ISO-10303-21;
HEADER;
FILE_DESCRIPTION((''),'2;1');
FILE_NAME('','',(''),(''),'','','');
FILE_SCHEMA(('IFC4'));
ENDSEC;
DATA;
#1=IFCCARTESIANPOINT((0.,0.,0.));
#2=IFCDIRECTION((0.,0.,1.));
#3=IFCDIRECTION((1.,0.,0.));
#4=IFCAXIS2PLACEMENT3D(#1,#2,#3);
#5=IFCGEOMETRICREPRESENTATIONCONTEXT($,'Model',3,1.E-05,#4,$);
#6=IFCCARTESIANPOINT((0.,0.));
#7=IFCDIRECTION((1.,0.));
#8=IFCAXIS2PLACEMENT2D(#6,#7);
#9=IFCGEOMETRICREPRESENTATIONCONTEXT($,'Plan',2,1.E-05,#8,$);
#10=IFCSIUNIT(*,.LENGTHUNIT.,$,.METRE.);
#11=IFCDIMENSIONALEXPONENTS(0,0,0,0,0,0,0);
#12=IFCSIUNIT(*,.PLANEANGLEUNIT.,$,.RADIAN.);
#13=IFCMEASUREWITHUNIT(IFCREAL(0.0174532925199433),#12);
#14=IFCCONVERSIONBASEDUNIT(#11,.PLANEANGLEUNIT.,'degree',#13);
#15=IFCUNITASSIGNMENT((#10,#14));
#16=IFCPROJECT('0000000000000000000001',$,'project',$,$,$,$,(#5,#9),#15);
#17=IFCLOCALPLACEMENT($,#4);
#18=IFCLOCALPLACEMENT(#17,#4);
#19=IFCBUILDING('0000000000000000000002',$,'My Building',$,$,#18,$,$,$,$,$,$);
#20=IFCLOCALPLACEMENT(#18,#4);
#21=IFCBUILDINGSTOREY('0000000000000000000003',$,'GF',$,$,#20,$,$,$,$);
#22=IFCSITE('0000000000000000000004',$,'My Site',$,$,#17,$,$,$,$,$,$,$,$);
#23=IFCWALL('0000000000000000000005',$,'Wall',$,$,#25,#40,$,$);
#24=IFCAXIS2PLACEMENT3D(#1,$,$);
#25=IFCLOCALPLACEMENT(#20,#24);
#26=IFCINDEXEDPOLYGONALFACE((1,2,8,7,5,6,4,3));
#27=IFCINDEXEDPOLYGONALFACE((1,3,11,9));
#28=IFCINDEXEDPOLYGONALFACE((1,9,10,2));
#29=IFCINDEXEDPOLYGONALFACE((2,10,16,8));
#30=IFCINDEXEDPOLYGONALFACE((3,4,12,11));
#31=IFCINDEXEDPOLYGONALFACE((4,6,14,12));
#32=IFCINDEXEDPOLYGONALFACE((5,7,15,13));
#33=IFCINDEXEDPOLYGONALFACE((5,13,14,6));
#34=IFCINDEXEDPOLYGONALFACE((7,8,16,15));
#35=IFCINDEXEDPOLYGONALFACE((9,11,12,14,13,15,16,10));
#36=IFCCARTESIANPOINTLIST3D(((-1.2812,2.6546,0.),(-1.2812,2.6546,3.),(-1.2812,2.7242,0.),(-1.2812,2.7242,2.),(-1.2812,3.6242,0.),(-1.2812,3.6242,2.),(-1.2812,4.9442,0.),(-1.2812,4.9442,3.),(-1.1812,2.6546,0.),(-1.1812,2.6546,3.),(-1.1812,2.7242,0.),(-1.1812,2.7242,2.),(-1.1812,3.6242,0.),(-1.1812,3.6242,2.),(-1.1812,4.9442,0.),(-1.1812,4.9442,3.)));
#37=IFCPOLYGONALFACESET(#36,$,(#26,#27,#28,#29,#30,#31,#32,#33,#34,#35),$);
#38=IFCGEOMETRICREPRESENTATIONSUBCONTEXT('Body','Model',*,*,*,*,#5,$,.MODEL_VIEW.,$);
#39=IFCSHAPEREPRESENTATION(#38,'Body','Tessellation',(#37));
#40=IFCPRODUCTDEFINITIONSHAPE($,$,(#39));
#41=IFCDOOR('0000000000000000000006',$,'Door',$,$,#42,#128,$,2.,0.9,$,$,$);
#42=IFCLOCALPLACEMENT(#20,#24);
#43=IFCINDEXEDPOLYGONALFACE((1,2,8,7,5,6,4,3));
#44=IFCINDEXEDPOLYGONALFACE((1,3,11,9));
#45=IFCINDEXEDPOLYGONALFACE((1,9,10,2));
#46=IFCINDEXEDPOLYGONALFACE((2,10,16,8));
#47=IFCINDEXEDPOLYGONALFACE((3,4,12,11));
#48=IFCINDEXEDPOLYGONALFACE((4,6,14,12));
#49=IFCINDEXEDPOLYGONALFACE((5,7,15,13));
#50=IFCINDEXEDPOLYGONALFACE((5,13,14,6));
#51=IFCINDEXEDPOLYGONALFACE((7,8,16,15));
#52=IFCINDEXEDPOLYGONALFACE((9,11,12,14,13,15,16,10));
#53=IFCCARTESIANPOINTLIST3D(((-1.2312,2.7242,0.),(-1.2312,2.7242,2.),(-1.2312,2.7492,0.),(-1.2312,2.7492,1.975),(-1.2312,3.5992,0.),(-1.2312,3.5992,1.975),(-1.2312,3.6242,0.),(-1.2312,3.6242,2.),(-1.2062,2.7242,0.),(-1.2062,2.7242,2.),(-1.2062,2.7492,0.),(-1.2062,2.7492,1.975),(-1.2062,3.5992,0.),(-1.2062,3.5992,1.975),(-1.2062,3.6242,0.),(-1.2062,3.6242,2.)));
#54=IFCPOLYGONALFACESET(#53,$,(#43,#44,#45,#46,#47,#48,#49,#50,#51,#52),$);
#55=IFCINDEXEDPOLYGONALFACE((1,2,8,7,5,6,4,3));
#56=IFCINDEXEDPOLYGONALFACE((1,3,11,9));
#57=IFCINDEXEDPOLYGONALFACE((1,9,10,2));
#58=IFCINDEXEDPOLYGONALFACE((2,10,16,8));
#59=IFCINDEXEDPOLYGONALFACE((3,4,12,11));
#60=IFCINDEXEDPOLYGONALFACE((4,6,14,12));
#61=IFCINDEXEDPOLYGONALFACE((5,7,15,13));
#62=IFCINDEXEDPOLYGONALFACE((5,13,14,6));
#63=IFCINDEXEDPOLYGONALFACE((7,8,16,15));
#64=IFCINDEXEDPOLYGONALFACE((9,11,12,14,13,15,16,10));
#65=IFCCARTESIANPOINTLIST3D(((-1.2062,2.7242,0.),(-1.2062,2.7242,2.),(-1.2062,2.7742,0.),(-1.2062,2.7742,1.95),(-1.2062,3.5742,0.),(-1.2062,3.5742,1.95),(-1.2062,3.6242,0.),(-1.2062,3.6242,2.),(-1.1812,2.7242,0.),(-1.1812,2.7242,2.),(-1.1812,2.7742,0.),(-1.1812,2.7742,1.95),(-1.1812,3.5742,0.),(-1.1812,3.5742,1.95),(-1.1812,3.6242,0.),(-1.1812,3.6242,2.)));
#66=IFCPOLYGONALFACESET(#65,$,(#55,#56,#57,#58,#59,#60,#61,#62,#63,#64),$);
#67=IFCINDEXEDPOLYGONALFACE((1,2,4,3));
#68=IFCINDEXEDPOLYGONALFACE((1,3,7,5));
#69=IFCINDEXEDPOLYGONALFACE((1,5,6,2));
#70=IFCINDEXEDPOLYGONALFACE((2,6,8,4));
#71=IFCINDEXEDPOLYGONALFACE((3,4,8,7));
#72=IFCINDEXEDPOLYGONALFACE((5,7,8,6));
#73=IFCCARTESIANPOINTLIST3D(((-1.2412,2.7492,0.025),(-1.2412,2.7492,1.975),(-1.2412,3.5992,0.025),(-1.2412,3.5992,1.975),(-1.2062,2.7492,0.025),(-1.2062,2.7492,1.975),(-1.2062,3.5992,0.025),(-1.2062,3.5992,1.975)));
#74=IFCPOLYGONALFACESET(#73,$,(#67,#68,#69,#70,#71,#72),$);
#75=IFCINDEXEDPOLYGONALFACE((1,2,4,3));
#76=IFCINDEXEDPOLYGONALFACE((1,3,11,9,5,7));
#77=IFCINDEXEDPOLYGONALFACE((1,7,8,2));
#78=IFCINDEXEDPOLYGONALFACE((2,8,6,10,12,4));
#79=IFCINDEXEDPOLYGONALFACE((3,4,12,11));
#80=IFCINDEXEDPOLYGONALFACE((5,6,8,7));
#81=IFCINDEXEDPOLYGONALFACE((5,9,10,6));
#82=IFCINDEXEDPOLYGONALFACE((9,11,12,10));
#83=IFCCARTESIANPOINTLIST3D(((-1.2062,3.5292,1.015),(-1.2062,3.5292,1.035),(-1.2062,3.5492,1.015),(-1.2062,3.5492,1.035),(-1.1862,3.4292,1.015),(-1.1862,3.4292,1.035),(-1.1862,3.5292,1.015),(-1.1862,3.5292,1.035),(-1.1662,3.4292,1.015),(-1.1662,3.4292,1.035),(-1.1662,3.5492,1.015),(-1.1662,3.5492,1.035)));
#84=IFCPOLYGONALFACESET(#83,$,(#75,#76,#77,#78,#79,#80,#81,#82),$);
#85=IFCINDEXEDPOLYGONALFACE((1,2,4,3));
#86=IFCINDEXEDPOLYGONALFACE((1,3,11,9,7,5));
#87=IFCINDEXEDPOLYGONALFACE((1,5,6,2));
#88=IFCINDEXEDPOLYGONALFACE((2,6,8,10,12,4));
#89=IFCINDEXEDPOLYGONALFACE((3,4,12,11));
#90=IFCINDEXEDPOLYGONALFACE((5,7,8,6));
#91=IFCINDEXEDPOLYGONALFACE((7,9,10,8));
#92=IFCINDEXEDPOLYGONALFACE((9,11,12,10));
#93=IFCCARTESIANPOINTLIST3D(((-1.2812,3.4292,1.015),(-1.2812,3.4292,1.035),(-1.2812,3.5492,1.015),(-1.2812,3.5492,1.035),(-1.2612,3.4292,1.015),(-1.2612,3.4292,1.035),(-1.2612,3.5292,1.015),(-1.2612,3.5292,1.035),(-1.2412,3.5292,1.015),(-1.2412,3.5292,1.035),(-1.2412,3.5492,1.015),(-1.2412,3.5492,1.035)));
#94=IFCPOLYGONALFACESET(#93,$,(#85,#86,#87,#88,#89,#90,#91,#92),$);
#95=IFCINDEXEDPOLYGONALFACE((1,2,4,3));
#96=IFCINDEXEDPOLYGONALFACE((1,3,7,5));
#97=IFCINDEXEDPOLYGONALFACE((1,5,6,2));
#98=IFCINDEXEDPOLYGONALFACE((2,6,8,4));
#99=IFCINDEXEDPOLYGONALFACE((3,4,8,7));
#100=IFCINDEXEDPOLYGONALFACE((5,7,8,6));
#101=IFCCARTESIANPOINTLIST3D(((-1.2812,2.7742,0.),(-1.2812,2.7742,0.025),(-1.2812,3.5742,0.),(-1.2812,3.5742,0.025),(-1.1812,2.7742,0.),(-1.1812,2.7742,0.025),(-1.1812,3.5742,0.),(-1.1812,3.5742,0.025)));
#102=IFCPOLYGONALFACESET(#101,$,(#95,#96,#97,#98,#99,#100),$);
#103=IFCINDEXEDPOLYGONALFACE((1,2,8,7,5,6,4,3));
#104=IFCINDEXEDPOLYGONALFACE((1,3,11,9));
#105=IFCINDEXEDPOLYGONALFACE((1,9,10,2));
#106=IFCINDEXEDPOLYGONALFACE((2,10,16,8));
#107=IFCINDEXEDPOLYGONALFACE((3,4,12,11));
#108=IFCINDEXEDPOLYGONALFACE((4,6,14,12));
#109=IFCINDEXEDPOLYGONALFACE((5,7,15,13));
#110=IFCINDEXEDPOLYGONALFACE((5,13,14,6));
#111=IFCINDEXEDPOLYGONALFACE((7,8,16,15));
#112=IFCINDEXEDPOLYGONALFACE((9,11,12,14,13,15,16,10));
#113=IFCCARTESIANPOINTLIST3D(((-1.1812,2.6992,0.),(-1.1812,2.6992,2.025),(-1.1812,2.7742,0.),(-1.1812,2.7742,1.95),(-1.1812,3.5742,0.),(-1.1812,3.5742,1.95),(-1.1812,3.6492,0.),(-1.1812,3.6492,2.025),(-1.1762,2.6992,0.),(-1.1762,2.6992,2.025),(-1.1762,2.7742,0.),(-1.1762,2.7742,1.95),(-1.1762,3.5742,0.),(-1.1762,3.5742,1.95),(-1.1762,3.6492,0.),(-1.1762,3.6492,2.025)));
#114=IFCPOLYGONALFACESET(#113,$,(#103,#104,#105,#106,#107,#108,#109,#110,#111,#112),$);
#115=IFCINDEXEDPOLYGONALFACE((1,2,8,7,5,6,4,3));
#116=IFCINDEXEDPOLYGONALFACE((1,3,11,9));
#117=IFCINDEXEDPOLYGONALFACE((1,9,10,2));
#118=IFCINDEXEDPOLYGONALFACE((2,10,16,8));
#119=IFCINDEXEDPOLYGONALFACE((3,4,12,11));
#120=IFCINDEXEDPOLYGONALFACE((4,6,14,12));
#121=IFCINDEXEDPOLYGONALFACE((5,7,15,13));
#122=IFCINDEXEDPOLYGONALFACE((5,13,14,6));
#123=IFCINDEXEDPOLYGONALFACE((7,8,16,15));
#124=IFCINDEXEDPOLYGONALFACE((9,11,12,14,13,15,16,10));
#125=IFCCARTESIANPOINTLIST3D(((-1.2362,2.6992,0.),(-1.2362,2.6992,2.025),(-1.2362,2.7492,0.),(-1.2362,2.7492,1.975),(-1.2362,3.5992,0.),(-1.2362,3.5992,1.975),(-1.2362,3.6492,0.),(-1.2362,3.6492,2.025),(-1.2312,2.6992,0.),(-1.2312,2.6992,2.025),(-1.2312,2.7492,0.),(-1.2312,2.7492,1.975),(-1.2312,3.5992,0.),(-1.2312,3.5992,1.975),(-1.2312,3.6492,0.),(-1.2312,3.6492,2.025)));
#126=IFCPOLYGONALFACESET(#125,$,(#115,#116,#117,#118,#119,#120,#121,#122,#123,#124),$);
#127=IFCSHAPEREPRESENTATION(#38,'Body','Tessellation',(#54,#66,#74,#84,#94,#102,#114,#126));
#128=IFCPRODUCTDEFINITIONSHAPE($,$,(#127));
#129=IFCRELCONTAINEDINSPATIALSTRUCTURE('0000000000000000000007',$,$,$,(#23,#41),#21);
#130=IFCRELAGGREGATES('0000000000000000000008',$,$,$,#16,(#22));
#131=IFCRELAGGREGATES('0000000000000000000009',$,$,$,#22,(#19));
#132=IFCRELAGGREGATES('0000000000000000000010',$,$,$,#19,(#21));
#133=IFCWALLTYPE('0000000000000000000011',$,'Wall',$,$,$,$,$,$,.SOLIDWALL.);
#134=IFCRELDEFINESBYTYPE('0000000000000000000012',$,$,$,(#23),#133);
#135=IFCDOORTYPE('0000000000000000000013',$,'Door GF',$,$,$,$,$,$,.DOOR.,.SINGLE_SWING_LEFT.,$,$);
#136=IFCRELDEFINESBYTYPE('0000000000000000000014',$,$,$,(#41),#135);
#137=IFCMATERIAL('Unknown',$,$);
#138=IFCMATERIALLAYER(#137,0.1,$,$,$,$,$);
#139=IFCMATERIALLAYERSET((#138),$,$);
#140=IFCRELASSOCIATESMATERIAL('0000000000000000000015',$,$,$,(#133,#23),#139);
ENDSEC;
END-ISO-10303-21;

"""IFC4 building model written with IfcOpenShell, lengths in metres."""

from ifc_helpers import new_model, entity, si_unit, converted_unit, frame, origin_with_axes, origin_2d_with_axis, place, context, subcontext, project, spatial, line, indexed_curve, outline, extrude, shape, source, transform, mapped, material, layer, layer_set, layer_usage, type_object, type_shapes, element, fill, save


model = new_model("IFC4")

# Units and contexts
model_context = context("Model", 3, precision=1e-05, world=origin_with_axes())
plan_context = context("Plan", 2, precision=1e-05, world=origin_2d_with_axis())
body_context_1 = subcontext(model_context, "Body", "Model", "MODEL_VIEW")
body_context_2 = subcontext(plan_context, "Body", "Plan", "PLAN_VIEW")
ifc_project = project(units=[si_unit("LENGTHUNIT", "METRE"), converted_unit("PLANEANGLEUNIT", "degree", entity("IfcReal", 0.0174532925199433), si_unit("PLANEANGLEUNIT", "RADIAN"), dimensions=[0, 0, 0, 0, 0, 0, 0])], contexts=[model_context, plan_context])

# Site, building, storey
site_placement = place(None, origin_with_axes())
site = spatial("IfcSite", under=ifc_project, at=site_placement, Name="My Site")
building_placement = place(site_placement, origin_with_axes())
building = spatial("IfcBuilding", under=site, at=building_placement, Name="My Building")
storey_placement = place(building_placement, origin_with_axes())
storey = spatial("IfcBuildingStorey", under=building, at=storey_placement, Name="GF")

# Shared definitions
ifc_material = material(Name="Unknown")

# Shared definitions
ifc_layer_1 = layer(ifc_material, 0.1)
ifc_layer_set_1 = layer_set([ifc_layer_1])
wall_type = type_object("IfcWallType", Name="Wall", PredefinedType="SOLIDWALL", material=ifc_layer_set_1)
shared_shape_1 = source(origin_with_axes(), body_context_1, "Body", "SweptSolid", [
    extrude(outline(indexed_curve([(0.0, 0.0), (0.9, 0.0), (0.9, 2.0), (0.0, 2.0)], segments=[line(1, 2, 3, 4, 1)])), frame((0.0, -0.6, 0.0), z_axis=(0.0, -1.0, 0.0), x_axis=(1.0, 0.0, 0.0)), (0.0, 0.0, -1.0), 1.2),
])
door_type = type_object("IfcDoorType", Name="Door GF", OperationType="SINGLE_SWING_LEFT", PredefinedType="DOOR")
shared_shape_2 = source(origin_with_axes(), body_context_1, "Body", "SweptSolid", [
    extrude(outline(indexed_curve([(0.0, 0.0), (0.0, 2.0), (0.9, 2.0), (0.9, 0.0), (0.875, 0.0), (0.875, 1.975), (0.025, 1.975), (0.025, 0.0)], segments=[line(1, 2, 3, 4, 5, 6, 7, 8, 1)])), frame((0.0, 0.025, 0.0), z_axis=(0.0, -1.0, 0.0), x_axis=(1.0, 0.0, 0.0)), (0.0, 0.0, -1.0), 0.025),
    extrude(outline(indexed_curve([(0.0, 0.0), (0.0, 2.0), (0.9, 2.0), (0.9, 0.0), (0.85, 0.0), (0.85, 1.95), (0.05, 1.95), (0.05, 0.0)], segments=[line(1, 2, 3, 4, 5, 6, 7, 8, 1)])), frame((0.0, 0.0, 0.0), z_axis=(0.0, -1.0, 0.0), x_axis=(1.0, 0.0, 0.0)), (0.0, 0.0, -1.0), 0.025),
    extrude(outline(indexed_curve([(0.0, 0.0), (0.85, 0.0), (0.85, 0.035), (0.0, 0.035)], segments=[line(1, 2, 3, 4, 1)])), frame((0.025, 0.025, 0.025), z_axis=(0.0, 0.0, 1.0), x_axis=(1.0, 0.0, 0.0)), (0.0, 0.0, 1.0), 1.95),
    extrude(outline(indexed_curve([(0.0, 0.0), (0.0, -0.04), (-0.12, -0.04), (-0.12, -0.02), (-0.02, -0.02), (-0.02, 0.0)], segments=[line(1, 2, 3, 4, 5, 6, 1)])), frame((0.825, 0.025, 1.015), z_axis=(0.0, 0.0, 1.0), x_axis=(1.0, 0.0, 0.0)), (0.0, 0.0, 1.0), 0.02),
    extrude(outline(indexed_curve([(0.0, 0.0), (0.0, 0.04), (-0.12, 0.04), (-0.12, 0.02), (-0.02, 0.02), (-0.02, 0.0)], segments=[line(1, 2, 3, 4, 5, 6, 1)])), frame((0.825, 0.06, 1.015), z_axis=(0.0, 0.0, 1.0), x_axis=(1.0, 0.0, 0.0)), (0.0, 0.0, 1.0), 0.02),
    extrude(outline(indexed_curve([(0.0, 0.0), (0.8, 0.0), (0.8, 0.1), (0.0, 0.1)], segments=[line(1, 2, 3, 4, 1)])), frame((0.05, 0.0, 0.0), z_axis=(0.0, 0.0, 1.0), x_axis=(1.0, 0.0, 0.0)), (0.0, 0.0, 1.0), 0.025),
    extrude(outline(indexed_curve([(0.0, 0.0), (0.0, 2.025), (0.95, 2.025), (0.95, 0.0), (0.875, 0.0), (0.875, 1.95), (0.075, 1.95), (0.075, 0.0)], segments=[line(1, 2, 3, 4, 5, 6, 7, 8, 1)])), frame((-0.025, -0.005, 0.0), z_axis=(0.0, -1.0, 0.0), x_axis=(1.0, 0.0, 0.0)), (0.0, 0.0, -1.0), 0.005),
    extrude(outline(indexed_curve([(0.0, 0.0), (0.0, 2.025), (0.95, 2.025), (0.95, 0.0), (0.9, 0.0), (0.9, 1.975), (0.05, 1.975), (0.05, 0.0)], segments=[line(1, 2, 3, 4, 5, 6, 7, 8, 1)])), frame((-0.025, 0.05, 0.0), z_axis=(0.0, -1.0, 0.0), x_axis=(1.0, 0.0, 0.0)), (0.0, 0.0, -1.0), 0.005),
])
shared_shape_3 = source(origin_with_axes(), body_context_2, "Body", "Curve2D", [
    entity("IfcIndexedPolyCurve", entity("IfcCartesianPointList2D", [[0.0, 0.0], [0.0, 0.05], [0.025, 0.05], [0.025, 0.025], [0.05, 0.025], [0.05, 0.0]]), [entity("IfcLineIndex", [1, 2, 3, 4, 5, 6, 1])]),
    entity("IfcIndexedPolyCurve", entity("IfcCartesianPointList2D", [[0.9, 0.0], [0.9, 0.05], [0.875, 0.05], [0.875, 0.025], [0.85, 0.025], [0.85, 0.0]]), [entity("IfcLineIndex", [1, 2, 3, 4, 5, 6, 1])]),
    entity("IfcTrimmedCurve", entity("IfcEllipse", entity("IfcAxis2Placement2D", entity("IfcCartesianPoint", [0.06, 0.05]), entity("IfcDirection", [1.0, 0.0])), 0.815, 0.85), [entity("IfcCartesianPoint", [0.875, 0.05])], [entity("IfcCartesianPoint", [0.06, 0.9])], True, "CARTESIAN"),
    entity("IfcIndexedPolyCurve", entity("IfcCartesianPointList2D", [[0.025, 0.05], [0.06, 0.05], [0.06, 0.9], [0.025, 0.9]]), [entity("IfcLineIndex", [1, 2, 3, 4, 1])]),
])
type_shapes(door_type, [shared_shape_2, shared_shape_3])

# Wall, opening, door
ifc_layer_usage_1 = layer_usage(ifc_layer_set_1, "AXIS2", "POSITIVE", 0.0)
wall_1_placement = place(storey_placement, frame((-1.1812, 2.6546, 0.0), z_axis=(0.0, 0.0, 1.0), x_axis=(0.0, 1.0, 0.0)))
wall_1 = element("IfcWall", 1, at=wall_1_placement, inside=storey, type_object=wall_type, material=ifc_layer_usage_1, Name="Wall", context=body_context_1, shape_type="SweptSolid", body=[
    extrude(outline(indexed_curve([(0.0, 0.0), (0.0, 0.1), (2.2896, 0.1), (2.2896, 0.0)], segments=[line(1, 2, 3, 4, 1)])), origin_with_axes(), (0.0, 0.0, 1.0), 3.0),
])
opening_1_placement = place(wall_1_placement, frame((0.0696, 0.0, 0.0), z_axis=(0.0, 0.0, 1.0), x_axis=(1.0, 0.0, 0.0)))
opening_1 = element("IfcOpeningElement", 2, at=opening_1_placement, cuts=wall_1, PredefinedType="OPENING", context=body_context_1, shape_type="MappedRepresentation", body=[
    mapped(shared_shape_1, transform((0.0, 0.0, 0.0), x_axis=(1.0, 0.0, 0.0), y_axis=(0.0, 1.0, 0.0), z_axis=(0.0, 0.0, 1.0), scale=1.0)),
])
door_1_placement = place(opening_1_placement, frame((0.0, 0.0, 0.0), z_axis=(0.0, 0.0, 1.0), x_axis=(1.0, 0.0, 0.0)))
door_1 = element("IfcDoor", 3, at=door_1_placement, inside=storey, type_object=door_type, Name="Door", OverallHeight=2.0, OverallWidth=0.9, shapes=[
    shape(body_context_1, "Body", "MappedRepresentation", [mapped(shared_shape_2, transform((0.0, 0.0, 0.0), x_axis=(1.0, 0.0, 0.0), y_axis=(0.0, 1.0, 0.0), z_axis=(0.0, 0.0, 1.0), scale=1.0))]),
    shape(body_context_2, "Body", "MappedRepresentation", [mapped(shared_shape_3, transform((0.0, 0.0, 0.0), x_axis=(1.0, 0.0, 0.0), y_axis=(0.0, 1.0, 0.0), z_axis=(0.0, 0.0, 1.0), scale=1.0))]),
])
fill(opening_1, door_1)

save(model, "model.ifc")
